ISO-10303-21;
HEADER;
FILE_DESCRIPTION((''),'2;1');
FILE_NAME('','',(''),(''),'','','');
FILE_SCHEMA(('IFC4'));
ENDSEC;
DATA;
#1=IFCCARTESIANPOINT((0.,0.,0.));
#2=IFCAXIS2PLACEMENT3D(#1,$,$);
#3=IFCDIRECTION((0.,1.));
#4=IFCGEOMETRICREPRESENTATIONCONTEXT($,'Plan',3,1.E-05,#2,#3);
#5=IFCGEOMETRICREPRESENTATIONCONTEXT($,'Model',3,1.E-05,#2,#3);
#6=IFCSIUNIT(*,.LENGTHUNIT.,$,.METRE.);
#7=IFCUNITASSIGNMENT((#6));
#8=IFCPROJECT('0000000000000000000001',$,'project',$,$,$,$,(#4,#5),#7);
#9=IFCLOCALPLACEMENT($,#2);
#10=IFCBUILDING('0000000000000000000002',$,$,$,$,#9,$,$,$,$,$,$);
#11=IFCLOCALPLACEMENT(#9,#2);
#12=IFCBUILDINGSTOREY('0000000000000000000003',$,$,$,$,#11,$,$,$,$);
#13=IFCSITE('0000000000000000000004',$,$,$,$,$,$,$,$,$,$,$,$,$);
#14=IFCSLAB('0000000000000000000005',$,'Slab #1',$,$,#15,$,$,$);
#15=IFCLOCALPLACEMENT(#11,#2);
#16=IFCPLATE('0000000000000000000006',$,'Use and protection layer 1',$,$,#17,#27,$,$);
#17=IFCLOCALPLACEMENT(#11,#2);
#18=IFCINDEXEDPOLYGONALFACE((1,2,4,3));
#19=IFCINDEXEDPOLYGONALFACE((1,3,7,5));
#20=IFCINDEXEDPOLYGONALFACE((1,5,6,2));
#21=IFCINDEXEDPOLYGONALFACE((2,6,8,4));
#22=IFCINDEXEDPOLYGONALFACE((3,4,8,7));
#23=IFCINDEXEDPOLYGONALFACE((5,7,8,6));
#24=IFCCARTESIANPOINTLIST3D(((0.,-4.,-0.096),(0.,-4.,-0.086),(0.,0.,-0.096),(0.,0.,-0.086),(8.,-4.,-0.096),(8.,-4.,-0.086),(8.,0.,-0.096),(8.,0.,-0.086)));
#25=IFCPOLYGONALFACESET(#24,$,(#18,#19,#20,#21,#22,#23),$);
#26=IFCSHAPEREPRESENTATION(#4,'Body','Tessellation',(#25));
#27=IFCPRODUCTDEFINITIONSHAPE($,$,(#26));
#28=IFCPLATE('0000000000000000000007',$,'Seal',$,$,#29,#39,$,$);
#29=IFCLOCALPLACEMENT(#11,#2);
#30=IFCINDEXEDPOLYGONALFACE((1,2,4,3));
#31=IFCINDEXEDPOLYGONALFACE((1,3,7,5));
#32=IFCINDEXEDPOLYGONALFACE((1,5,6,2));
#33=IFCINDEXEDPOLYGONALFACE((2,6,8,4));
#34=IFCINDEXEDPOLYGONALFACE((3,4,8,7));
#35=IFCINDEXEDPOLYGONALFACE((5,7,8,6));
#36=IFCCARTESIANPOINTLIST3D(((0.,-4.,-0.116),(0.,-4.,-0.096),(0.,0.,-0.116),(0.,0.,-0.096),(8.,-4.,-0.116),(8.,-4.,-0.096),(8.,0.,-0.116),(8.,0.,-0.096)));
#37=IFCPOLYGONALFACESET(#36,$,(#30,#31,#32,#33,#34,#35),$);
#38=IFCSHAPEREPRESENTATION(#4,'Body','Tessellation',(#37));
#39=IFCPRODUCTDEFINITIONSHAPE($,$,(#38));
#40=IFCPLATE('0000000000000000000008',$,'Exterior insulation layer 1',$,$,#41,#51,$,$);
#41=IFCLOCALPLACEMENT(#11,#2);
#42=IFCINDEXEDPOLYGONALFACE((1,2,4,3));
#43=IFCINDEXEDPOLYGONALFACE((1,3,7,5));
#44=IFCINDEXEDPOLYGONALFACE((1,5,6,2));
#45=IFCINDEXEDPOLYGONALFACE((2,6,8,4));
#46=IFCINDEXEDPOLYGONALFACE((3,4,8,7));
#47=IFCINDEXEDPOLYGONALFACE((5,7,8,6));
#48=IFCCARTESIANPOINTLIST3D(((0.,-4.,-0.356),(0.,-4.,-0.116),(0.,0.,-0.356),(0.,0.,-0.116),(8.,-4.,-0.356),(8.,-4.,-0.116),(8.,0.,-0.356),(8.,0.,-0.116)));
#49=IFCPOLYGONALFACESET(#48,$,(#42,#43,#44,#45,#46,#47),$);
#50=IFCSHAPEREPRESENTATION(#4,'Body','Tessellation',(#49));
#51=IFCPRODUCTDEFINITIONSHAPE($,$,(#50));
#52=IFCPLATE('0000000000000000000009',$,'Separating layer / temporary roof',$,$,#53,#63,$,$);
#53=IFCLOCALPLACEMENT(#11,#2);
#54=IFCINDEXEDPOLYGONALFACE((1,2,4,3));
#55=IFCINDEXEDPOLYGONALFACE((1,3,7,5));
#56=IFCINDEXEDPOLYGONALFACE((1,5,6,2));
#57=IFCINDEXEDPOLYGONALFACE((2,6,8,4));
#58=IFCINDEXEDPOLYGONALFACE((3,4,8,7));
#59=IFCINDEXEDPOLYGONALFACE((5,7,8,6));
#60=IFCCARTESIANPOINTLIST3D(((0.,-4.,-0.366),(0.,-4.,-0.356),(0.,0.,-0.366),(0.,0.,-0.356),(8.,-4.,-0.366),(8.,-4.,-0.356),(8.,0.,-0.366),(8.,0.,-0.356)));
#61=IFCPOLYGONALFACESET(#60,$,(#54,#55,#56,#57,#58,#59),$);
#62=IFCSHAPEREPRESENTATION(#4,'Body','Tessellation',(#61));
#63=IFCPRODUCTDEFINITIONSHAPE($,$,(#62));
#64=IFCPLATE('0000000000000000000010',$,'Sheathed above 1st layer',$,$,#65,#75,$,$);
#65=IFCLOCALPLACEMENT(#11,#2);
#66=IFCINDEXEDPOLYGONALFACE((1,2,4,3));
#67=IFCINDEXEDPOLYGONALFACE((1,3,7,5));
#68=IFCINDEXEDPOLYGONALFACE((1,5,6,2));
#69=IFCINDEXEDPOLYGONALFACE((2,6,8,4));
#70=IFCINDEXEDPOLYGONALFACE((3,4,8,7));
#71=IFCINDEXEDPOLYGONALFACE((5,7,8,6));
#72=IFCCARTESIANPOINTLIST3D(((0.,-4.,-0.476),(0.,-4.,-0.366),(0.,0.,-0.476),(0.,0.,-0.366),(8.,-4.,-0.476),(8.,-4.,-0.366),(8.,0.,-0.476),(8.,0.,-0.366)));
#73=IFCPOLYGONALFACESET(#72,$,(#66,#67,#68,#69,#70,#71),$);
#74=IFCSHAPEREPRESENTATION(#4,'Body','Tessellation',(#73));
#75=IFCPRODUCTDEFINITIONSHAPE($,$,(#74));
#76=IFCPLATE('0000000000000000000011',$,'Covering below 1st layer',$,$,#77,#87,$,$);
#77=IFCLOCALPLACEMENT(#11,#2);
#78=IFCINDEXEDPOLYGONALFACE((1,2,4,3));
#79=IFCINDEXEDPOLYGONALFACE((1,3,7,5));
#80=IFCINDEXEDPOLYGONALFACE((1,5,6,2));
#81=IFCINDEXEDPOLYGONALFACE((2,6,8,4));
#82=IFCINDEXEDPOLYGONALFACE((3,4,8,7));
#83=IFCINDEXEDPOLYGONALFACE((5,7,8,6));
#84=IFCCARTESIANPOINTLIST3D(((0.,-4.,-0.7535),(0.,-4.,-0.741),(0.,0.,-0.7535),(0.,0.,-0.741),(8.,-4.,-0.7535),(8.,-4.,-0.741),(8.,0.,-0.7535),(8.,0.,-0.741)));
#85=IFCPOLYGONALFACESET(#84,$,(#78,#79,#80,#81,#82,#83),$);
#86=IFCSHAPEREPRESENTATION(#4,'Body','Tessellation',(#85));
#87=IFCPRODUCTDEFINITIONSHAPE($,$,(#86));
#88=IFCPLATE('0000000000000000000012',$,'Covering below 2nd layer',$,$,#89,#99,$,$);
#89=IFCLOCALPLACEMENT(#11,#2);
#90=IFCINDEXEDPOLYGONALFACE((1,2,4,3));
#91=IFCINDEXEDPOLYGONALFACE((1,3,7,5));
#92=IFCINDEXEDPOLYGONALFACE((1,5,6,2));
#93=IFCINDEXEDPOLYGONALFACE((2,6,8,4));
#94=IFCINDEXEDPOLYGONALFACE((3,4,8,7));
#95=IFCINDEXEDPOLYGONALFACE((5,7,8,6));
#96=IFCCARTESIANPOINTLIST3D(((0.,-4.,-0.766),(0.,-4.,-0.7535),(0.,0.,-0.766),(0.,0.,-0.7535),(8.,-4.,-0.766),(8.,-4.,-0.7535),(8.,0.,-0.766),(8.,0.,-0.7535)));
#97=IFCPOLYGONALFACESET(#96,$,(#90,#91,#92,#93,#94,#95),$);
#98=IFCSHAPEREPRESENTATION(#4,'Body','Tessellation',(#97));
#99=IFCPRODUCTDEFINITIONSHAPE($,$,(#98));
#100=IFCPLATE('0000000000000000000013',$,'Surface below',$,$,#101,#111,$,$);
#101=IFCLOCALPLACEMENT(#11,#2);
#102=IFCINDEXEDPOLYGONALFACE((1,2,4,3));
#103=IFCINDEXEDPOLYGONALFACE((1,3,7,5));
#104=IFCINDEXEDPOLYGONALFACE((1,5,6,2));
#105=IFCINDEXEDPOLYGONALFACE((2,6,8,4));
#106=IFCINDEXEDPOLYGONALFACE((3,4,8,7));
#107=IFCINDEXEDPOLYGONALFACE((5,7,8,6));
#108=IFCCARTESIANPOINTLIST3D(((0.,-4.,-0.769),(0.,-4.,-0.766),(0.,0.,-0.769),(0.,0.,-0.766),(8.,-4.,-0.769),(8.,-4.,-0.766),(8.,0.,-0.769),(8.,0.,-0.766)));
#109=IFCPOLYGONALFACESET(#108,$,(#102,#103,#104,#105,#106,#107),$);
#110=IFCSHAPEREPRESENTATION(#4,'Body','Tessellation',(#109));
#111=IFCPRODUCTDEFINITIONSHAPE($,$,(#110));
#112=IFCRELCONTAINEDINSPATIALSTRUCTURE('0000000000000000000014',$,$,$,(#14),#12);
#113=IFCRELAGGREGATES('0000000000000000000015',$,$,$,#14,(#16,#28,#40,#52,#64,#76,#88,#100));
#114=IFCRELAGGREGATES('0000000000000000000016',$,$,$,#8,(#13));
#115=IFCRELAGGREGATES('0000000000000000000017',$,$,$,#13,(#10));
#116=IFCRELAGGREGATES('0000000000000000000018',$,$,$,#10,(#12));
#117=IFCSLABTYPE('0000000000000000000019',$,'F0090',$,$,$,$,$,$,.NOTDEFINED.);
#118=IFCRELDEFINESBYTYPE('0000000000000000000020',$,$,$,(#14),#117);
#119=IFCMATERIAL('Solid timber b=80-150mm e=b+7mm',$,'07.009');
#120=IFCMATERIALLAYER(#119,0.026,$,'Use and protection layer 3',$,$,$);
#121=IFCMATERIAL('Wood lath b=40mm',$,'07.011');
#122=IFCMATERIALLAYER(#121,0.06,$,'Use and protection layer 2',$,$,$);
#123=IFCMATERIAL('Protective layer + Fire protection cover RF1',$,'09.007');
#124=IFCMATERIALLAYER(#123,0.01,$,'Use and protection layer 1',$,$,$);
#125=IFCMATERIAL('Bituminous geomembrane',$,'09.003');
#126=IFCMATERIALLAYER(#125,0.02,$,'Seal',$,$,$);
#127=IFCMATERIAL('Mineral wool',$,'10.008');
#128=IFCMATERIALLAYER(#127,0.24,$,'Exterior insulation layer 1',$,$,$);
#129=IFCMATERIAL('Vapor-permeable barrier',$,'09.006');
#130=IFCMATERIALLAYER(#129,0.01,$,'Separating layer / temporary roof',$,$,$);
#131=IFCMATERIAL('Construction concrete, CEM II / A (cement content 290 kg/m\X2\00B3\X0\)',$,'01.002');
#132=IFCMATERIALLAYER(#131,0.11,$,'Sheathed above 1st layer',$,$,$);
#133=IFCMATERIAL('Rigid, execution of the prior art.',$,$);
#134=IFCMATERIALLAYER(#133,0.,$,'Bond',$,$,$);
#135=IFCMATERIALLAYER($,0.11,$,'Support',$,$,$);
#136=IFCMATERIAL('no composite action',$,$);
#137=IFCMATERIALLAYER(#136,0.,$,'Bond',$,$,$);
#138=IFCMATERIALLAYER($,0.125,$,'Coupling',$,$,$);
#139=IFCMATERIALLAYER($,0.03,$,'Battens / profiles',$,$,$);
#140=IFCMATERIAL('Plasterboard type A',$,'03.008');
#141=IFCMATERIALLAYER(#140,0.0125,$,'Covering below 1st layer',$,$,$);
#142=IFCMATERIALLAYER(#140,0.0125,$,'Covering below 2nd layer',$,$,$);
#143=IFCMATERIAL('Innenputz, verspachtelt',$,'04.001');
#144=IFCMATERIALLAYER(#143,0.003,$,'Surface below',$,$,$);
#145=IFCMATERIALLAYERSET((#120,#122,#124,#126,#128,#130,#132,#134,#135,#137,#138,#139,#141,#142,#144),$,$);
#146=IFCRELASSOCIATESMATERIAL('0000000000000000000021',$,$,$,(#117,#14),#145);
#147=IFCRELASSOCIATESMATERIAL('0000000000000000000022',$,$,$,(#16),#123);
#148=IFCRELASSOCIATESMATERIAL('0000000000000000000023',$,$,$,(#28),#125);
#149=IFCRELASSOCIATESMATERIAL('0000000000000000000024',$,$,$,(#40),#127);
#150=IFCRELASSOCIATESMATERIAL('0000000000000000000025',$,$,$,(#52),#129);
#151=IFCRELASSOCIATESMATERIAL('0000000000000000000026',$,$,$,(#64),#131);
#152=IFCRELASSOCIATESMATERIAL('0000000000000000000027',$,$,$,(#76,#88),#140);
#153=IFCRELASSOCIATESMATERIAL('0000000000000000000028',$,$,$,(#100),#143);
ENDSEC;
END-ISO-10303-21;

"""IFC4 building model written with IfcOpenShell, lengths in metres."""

from ifc_helpers import new_model, si_unit, direction, frame, frame_2d, origin, place, context, project, spatial, rectangle, extrude, material, layer, layer_set, type_object, element, aggregate, save


model = new_model("IFC4")

# Units and contexts
plan_context = context("Plan", 3, precision=1e-05, world=origin(), true_north=direction((0.0, 1.0)))
model_context = context("Model", 3, precision=1e-05, world=origin(), true_north=direction((0.0, 1.0)))
ifc_project = project(units=[si_unit("LENGTHUNIT", "METRE")], contexts=[plan_context, model_context])

# Site, building, storey
site = spatial("IfcSite", under=ifc_project)
building_placement = place(None, origin())
building = spatial("IfcBuilding", under=site, at=building_placement)
storey_placement = place(building_placement, origin())
storey = spatial("IfcBuildingStorey", under=building, at=storey_placement)

# Slab, plates
ifc_material_1 = material(Name="Solid timber b=80-150mm e=b+7mm", Category="07.009")
ifc_layer_1 = layer(ifc_material_1, 0.026, Name="Use and protection layer 3")
ifc_material_2 = material(Name="Wood lath b=40mm", Category="07.011")
ifc_layer_2 = layer(ifc_material_2, 0.06, Name="Use and protection layer 2")
ifc_material_3 = material(Name="Protective layer + Fire protection cover RF1", Category="09.007")
ifc_layer_3 = layer(ifc_material_3, 0.01, Name="Use and protection layer 1")
ifc_material_4 = material(Name="Bituminous geomembrane", Category="09.003")
ifc_layer_4 = layer(ifc_material_4, 0.02, Name="Seal")
ifc_material_5 = material(Name="Mineral wool", Category="10.008")
ifc_layer_5 = layer(ifc_material_5, 0.24, Name="Exterior insulation layer 1")
ifc_material_6 = material(Name="Vapor-permeable barrier", Category="09.006")
ifc_layer_6 = layer(ifc_material_6, 0.01, Name="Separating layer / temporary roof")
ifc_material_7 = material(Name="Construction concrete, CEM II / A (cement content 290 kg/m³)", Category="01.002")
ifc_layer_7 = layer(ifc_material_7, 0.11, Name="Sheathed above 1st layer")
ifc_material_8 = material(Name="Rigid, execution of the prior art.")
ifc_layer_8 = layer(ifc_material_8, 0.0, Name="Bond")
ifc_layer_9 = layer(None, 0.11, Name="Support")
ifc_material_9 = material(Name="no composite action")
ifc_layer_10 = layer(ifc_material_9, 0.0, Name="Bond")
ifc_layer_11 = layer(None, 0.125, Name="Coupling")
ifc_layer_12 = layer(None, 0.03, Name="Battens / profiles")
ifc_material_10 = material(Name="Plasterboard type A", Category="03.008")
ifc_layer_13 = layer(ifc_material_10, 0.0125, Name="Covering below 1st layer")
ifc_layer_14 = layer(ifc_material_10, 0.0125, Name="Covering below 2nd layer")
ifc_material_11 = material(Name="Innenputz, verspachtelt", Category="04.001")
ifc_layer_15 = layer(ifc_material_11, 0.003, Name="Surface below")
ifc_layer_set = layer_set([ifc_layer_1, ifc_layer_2, ifc_layer_3, ifc_layer_4, ifc_layer_5, ifc_layer_6, ifc_layer_7, ifc_layer_8, ifc_layer_9, ifc_layer_10, ifc_layer_11, ifc_layer_12, ifc_layer_13, ifc_layer_14, ifc_layer_15])
slab_type = type_object("IfcSlabType", Name="F0090", PredefinedType="NOTDEFINED", material=ifc_layer_set)
slab_placement = place(None, frame((0.0, 0.0, 0.0), z_axis=(0.0, 0.0, -1.0), x_axis=(1.0, 0.0, 0.0)))
slab = element("IfcSlab", 1, at=slab_placement, inside=storey, type_object=slab_type, material=ifc_layer_set, Name="Slab #1")
plate_1_placement = place(slab_placement, origin())
plate_1 = element("IfcPlate", 2, at=plate_1_placement, material=ifc_material_3, Name="Use and protection layer 1", context=plan_context, shape_type="SweptSolid", body=[
    extrude(rectangle(XDim=8.0, YDim=4.0, at=frame_2d((4.0, 2.0), x_axis=(1.0, 0.0))), frame((0.0, 0.0, 0.086), z_axis=(0.0, 0.0, 1.0), x_axis=(1.0, 0.0, 0.0)), (0.0, 0.0, 1.0), 0.01),
])
plate_2_placement = place(slab_placement, origin())
plate_2 = element("IfcPlate", 3, at=plate_2_placement, material=ifc_material_4, Name="Seal", context=plan_context, shape_type="SweptSolid", body=[
    extrude(rectangle(XDim=8.0, YDim=4.0, at=frame_2d((4.0, 2.0), x_axis=(1.0, 0.0))), frame((0.0, 0.0, 0.096), z_axis=(0.0, 0.0, 1.0), x_axis=(1.0, 0.0, 0.0)), (0.0, 0.0, 1.0), 0.02),
])
plate_3_placement = place(slab_placement, origin())
plate_3 = element("IfcPlate", 4, at=plate_3_placement, material=ifc_material_5, Name="Exterior insulation layer 1", context=plan_context, shape_type="SweptSolid", body=[
    extrude(rectangle(XDim=8.0, YDim=4.0, at=frame_2d((4.0, 2.0), x_axis=(1.0, 0.0))), frame((0.0, 0.0, 0.116), z_axis=(0.0, 0.0, 1.0), x_axis=(1.0, 0.0, 0.0)), (0.0, 0.0, 1.0), 0.24),
])
plate_4_placement = place(slab_placement, origin())
plate_4 = element("IfcPlate", 5, at=plate_4_placement, material=ifc_material_6, Name="Separating layer / temporary roof", context=plan_context, shape_type="SweptSolid", body=[
    extrude(rectangle(XDim=8.0, YDim=4.0, at=frame_2d((4.0, 2.0), x_axis=(1.0, 0.0))), frame((0.0, 0.0, 0.356), z_axis=(0.0, 0.0, 1.0), x_axis=(1.0, 0.0, 0.0)), (0.0, 0.0, 1.0), 0.01),
])
plate_5_placement = place(slab_placement, origin())
plate_5 = element("IfcPlate", 6, at=plate_5_placement, material=ifc_material_7, Name="Sheathed above 1st layer", context=plan_context, shape_type="SweptSolid", body=[
    extrude(rectangle(XDim=8.0, YDim=4.0, at=frame_2d((4.0, 2.0), x_axis=(1.0, 0.0))), frame((0.0, 0.0, 0.366), z_axis=(0.0, 0.0, 1.0), x_axis=(1.0, 0.0, 0.0)), (0.0, 0.0, 1.0), 0.11),
])
plate_6_placement = place(slab_placement, origin())
plate_6 = element("IfcPlate", 7, at=plate_6_placement, material=ifc_material_10, Name="Covering below 1st layer", context=plan_context, shape_type="SweptSolid", body=[
    extrude(rectangle(XDim=8.0, YDim=4.0, at=frame_2d((4.0, 2.0), x_axis=(1.0, 0.0))), frame((0.0, 0.0, 0.741), z_axis=(0.0, 0.0, 1.0), x_axis=(1.0, 0.0, 0.0)), (0.0, 0.0, 1.0), 0.0125),
])
plate_7_placement = place(slab_placement, origin())
plate_7 = element("IfcPlate", 8, at=plate_7_placement, material=ifc_material_10, Name="Covering below 2nd layer", context=plan_context, shape_type="SweptSolid", body=[
    extrude(rectangle(XDim=8.0, YDim=4.0, at=frame_2d((4.0, 2.0), x_axis=(1.0, 0.0))), frame((0.0, 0.0, 0.7535), z_axis=(0.0, 0.0, 1.0), x_axis=(1.0, 0.0, 0.0)), (0.0, 0.0, 1.0), 0.0125),
])
plate_8_placement = place(slab_placement, origin())
plate_8 = element("IfcPlate", 9, at=plate_8_placement, material=ifc_material_11, Name="Surface below", context=plan_context, shape_type="SweptSolid", body=[
    extrude(rectangle(XDim=8.0, YDim=4.0, at=frame_2d((4.0, 2.0), x_axis=(1.0, 0.0))), frame((0.0, 0.0, 0.766), z_axis=(0.0, 0.0, 1.0), x_axis=(1.0, 0.0, 0.0)), (0.0, 0.0, 1.0), 0.003),
])
aggregate(slab, [plate_1, plate_2, plate_3, plate_4, plate_5, plate_6, plate_7, plate_8])

save(model, "model.ifc")
